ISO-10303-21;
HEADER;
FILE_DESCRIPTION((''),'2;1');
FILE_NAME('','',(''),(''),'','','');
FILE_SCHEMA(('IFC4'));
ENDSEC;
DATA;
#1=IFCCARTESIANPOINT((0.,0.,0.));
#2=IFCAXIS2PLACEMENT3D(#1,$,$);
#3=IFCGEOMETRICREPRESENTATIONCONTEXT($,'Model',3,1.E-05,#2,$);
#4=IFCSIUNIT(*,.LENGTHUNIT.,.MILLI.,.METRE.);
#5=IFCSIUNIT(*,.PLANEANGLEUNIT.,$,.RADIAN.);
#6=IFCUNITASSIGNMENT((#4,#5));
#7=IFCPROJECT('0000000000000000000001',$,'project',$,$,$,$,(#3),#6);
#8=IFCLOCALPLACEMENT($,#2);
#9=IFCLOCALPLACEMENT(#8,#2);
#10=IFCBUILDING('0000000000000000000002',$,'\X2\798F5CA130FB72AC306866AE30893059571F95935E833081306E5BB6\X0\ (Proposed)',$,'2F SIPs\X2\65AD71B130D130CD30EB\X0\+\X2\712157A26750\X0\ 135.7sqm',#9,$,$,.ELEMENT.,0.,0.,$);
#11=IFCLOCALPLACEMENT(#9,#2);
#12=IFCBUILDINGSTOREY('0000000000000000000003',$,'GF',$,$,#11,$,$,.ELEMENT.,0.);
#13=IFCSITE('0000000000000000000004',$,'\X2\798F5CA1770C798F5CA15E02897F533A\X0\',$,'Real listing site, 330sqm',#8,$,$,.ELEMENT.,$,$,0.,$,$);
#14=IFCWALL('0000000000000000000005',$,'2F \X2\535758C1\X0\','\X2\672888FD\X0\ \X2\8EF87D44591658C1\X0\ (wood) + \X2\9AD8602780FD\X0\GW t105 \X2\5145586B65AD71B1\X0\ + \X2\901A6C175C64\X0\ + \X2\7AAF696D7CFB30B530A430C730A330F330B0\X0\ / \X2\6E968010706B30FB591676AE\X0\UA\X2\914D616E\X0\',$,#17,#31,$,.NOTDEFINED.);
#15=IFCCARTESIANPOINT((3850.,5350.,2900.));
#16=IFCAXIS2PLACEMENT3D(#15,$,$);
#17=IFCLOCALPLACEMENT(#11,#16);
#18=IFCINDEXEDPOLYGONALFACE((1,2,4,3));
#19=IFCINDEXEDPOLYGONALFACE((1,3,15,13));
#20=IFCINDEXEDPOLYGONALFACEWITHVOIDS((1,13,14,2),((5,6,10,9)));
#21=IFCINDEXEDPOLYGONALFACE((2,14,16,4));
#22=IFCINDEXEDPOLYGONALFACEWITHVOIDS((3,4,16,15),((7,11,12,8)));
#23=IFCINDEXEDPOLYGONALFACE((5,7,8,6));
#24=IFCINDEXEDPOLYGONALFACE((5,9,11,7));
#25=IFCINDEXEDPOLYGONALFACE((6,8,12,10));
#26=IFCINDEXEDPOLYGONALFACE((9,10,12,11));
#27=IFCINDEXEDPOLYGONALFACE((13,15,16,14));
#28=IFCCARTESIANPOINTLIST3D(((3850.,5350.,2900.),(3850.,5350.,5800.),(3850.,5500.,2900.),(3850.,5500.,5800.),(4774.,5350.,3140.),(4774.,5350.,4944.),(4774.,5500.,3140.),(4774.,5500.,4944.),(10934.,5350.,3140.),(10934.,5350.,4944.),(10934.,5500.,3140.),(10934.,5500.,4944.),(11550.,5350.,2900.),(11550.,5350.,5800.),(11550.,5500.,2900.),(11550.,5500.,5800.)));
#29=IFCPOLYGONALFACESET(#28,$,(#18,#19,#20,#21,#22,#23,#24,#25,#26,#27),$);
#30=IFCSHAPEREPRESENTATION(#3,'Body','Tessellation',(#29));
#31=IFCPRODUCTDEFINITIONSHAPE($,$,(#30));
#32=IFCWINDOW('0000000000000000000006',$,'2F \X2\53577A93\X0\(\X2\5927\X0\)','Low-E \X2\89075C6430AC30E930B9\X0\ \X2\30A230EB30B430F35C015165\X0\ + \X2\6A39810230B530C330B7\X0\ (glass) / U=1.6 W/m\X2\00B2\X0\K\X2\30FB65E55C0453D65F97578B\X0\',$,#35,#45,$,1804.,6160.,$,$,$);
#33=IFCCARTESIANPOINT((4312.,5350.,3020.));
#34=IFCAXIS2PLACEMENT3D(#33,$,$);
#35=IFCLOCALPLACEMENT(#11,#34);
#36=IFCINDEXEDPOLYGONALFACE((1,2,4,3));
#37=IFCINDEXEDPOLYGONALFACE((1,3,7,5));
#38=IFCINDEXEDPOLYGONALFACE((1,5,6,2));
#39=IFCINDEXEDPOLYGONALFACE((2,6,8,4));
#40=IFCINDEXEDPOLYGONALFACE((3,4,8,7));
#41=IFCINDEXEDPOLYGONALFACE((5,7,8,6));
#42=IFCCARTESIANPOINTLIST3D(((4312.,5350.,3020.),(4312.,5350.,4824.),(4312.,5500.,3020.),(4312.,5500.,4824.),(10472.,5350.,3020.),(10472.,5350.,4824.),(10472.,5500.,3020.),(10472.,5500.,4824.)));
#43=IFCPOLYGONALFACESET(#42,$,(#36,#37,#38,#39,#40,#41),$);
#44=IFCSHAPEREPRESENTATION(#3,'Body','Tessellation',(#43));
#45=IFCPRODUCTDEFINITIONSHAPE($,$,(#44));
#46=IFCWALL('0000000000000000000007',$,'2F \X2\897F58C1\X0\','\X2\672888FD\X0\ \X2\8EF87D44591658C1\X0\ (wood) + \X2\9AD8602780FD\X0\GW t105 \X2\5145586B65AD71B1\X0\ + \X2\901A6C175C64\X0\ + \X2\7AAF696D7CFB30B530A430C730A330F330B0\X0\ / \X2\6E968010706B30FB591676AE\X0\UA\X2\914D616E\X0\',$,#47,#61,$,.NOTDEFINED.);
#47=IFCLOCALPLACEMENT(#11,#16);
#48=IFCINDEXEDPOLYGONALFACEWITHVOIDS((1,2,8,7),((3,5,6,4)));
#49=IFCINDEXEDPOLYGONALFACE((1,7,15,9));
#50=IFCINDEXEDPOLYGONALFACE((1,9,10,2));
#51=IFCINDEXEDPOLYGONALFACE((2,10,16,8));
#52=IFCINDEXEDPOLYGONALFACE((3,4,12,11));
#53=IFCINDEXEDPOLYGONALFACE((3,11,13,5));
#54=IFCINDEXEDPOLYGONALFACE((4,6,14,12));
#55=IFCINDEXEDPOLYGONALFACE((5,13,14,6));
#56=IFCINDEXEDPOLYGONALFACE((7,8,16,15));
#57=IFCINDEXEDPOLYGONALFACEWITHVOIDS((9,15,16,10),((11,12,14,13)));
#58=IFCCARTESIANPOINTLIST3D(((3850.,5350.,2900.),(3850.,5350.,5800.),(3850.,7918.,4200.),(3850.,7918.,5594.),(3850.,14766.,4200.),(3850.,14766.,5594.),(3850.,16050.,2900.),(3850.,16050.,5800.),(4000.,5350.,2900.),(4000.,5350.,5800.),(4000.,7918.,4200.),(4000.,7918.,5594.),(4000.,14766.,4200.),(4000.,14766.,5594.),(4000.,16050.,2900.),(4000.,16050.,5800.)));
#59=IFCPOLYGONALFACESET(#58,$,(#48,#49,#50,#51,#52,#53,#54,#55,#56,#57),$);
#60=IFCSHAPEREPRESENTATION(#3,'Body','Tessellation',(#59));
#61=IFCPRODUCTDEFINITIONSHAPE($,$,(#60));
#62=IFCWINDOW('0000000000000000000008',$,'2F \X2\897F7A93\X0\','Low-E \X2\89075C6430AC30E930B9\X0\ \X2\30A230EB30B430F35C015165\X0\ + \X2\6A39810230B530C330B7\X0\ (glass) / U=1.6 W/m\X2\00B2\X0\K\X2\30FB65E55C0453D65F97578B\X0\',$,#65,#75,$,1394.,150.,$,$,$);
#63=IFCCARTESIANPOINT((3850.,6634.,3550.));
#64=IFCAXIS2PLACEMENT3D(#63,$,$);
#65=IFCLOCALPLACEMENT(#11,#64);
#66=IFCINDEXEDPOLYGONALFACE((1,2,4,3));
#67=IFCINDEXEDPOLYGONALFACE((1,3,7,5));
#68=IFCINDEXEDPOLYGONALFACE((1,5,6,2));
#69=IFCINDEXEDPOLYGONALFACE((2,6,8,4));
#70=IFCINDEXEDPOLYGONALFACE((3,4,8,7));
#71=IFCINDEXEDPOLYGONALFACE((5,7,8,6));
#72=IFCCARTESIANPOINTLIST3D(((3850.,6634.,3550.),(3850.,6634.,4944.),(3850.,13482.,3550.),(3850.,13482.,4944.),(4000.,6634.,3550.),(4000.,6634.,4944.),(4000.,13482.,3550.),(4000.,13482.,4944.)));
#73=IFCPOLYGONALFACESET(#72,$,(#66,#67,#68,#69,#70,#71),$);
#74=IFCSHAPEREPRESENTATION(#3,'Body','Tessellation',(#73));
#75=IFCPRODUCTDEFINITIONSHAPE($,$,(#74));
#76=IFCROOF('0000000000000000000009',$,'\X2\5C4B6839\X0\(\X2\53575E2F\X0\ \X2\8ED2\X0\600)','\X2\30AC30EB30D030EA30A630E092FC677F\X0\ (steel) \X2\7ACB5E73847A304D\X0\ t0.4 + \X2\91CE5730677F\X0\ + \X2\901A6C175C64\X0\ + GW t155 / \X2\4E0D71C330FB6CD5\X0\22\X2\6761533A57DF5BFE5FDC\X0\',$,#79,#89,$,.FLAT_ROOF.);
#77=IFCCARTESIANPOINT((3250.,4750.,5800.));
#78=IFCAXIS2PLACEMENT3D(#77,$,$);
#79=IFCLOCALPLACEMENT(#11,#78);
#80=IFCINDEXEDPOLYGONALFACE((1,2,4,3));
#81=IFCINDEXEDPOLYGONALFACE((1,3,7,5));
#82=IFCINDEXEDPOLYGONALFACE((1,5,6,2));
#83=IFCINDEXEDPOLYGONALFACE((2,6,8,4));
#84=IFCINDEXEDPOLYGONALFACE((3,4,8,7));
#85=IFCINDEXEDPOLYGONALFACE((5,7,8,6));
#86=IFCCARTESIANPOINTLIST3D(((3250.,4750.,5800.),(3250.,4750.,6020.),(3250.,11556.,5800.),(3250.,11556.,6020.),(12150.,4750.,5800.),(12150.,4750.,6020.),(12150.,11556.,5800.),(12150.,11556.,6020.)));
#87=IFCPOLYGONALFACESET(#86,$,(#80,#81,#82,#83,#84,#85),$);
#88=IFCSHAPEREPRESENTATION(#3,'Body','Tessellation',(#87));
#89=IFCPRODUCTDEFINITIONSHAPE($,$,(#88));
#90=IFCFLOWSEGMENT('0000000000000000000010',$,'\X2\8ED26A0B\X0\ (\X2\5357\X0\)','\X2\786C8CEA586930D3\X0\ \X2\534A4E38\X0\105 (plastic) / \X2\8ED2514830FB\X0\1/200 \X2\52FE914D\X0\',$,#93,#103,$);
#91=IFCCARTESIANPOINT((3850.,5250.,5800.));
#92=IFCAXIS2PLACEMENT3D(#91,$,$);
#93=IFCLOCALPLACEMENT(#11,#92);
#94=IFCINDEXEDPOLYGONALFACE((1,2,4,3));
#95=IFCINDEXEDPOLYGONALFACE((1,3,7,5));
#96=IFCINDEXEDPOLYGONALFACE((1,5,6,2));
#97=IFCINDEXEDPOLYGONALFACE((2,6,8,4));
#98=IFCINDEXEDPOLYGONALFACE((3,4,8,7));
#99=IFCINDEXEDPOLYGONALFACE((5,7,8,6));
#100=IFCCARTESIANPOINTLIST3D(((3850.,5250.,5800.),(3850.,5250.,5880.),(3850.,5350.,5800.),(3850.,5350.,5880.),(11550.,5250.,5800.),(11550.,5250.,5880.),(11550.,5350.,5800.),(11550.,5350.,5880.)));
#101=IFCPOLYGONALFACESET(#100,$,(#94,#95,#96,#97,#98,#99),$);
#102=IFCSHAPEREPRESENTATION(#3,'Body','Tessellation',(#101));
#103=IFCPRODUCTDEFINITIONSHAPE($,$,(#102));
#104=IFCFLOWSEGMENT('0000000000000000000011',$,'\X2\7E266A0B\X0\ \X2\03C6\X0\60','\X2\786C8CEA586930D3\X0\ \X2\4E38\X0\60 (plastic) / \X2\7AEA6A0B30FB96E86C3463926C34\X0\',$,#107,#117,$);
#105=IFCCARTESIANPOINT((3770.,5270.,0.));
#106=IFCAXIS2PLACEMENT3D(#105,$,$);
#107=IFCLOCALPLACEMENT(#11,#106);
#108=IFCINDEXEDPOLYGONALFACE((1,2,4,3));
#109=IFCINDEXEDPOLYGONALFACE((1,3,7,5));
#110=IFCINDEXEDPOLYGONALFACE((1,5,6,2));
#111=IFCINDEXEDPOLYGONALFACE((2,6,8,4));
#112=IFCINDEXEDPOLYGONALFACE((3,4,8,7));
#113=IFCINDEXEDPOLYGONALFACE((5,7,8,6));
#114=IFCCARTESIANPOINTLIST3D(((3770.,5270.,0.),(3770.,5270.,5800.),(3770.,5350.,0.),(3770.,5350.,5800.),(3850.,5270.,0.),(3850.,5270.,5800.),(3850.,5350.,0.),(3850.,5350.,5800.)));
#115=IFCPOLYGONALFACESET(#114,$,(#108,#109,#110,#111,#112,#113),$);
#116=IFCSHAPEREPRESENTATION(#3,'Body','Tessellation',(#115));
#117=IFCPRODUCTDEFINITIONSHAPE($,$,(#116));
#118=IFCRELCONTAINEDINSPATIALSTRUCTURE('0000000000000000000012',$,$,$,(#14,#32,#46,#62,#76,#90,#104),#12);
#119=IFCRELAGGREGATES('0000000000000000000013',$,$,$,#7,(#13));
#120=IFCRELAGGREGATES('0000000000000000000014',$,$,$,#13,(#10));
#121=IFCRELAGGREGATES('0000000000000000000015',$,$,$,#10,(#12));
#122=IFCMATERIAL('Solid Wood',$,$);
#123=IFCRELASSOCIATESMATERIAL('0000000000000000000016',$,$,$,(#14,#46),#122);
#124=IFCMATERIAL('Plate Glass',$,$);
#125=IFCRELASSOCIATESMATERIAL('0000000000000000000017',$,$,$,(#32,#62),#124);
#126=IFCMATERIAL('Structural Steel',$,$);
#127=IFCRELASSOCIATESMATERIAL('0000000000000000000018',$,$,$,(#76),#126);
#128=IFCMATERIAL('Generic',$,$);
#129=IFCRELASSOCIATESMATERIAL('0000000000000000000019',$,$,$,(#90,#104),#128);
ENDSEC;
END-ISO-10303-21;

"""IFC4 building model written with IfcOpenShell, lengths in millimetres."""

from ifc_helpers import new_model, si_unit, frame, frame_2d, origin, place, context, project, spatial, rectangle, extrude, material, element, fill, save


model = new_model("IFC4")

# Units and contexts
model_context = context("Model", 3, precision=1e-05, world=origin())
ifc_project = project(units=[si_unit("LENGTHUNIT", "METRE", prefix="MILLI"), si_unit("PLANEANGLEUNIT", "RADIAN")], contexts=[model_context])

# Site, building, storey
site_placement = place(None, origin())
site = spatial("IfcSite", under=ifc_project, at=site_placement, Name="福岡県福岡市西区", ObjectType="Real listing site, 330sqm", CompositionType="ELEMENT", RefElevation=0.0)
building_placement = place(site_placement, origin())
building = spatial("IfcBuilding", under=site, at=building_placement, Name="福岡・犬と暮らす土間広めの家 (Proposed)", ObjectType="2F SIPs断熱パネル+無垢材 135.7sqm", CompositionType="ELEMENT", ElevationOfRefHeight=0.0, ElevationOfTerrain=0.0)
storey_placement = place(building_placement, origin())
storey = spatial("IfcBuildingStorey", under=building, at=storey_placement, Name="GF", CompositionType="ELEMENT", Elevation=0.0)

# Shared definitions
ifc_material_1 = material(Name="Solid Wood")

# Shared definitions
ifc_material_2 = material(Name="Plate Glass")

# Walls, openings, windows
wall_1_placement = place(storey_placement, frame((3850.0, 5350.0, 2900.0)))
wall_1 = element("IfcWall", 1, at=wall_1_placement, inside=storey, material=ifc_material_1, Name="2F 南壁", Description="木製 軸組外壁 (wood) + 高性能GW t105 充填断熱 + 通気層 + 窯業系サイディング / 準耐火・外皮UA配慮", PredefinedType="NOTDEFINED", context=model_context, shape_type="SweptSolid", body=[
    extrude(rectangle(XDim=7700.0, YDim=150.0, at=frame_2d((3850.0, 75.0))), frame((3850.0, 5350.0, 2900.0)), (0.0, 0.0, 1.0), 2900.0),
])
opening_1_placement = place(storey_placement, frame((4312.0, 5350.0, 3020.0)))
opening_1 = element("IfcOpeningElement", 2, at=opening_1_placement, cuts=wall_1, PredefinedType="NOTDEFINED", context=model_context, shape_type="SweptSolid", body=[
    extrude(rectangle(XDim=6160.0, YDim=150.0, at=frame_2d((3080.0, 75.0))), frame((4312.0, 5350.0, 3020.0)), (0.0, 0.0, 1.0), 1804.0),
])
window_1_placement = place(storey_placement, frame((4312.0, 5350.0, 3020.0)))
window_1 = element("IfcWindow", 3, at=window_1_placement, inside=storey, material=ifc_material_2, Name="2F 南窓(大)", Description="Low-E 複層ガラス アルゴン封入 + 樹脂サッシ (glass) / U=1.6 W/m²K・日射取得型", OverallHeight=1804.0, OverallWidth=6160.0, context=model_context, shape_type="SweptSolid", body=[
    extrude(rectangle(XDim=6160.0, YDim=150.0, at=frame_2d((3080.0, 75.0))), frame((4312.0, 5350.0, 3020.0)), (0.0, 0.0, 1.0), 1804.0),
])
fill(opening_1, window_1)
wall_2_placement = place(storey_placement, frame((3850.0, 5350.0, 2900.0)))
wall_2 = element("IfcWall", 4, at=wall_2_placement, inside=storey, material=ifc_material_1, Name="2F 西壁", Description="木製 軸組外壁 (wood) + 高性能GW t105 充填断熱 + 通気層 + 窯業系サイディング / 準耐火・外皮UA配慮", PredefinedType="NOTDEFINED", context=model_context, shape_type="SweptSolid", body=[
    extrude(rectangle(XDim=150.0, YDim=10700.0, at=frame_2d((75.0, 5350.0))), frame((3850.0, 5350.0, 2900.0)), (0.0, 0.0, 1.0), 2900.0),
])
opening_2_placement = place(storey_placement, frame((3850.0, 6634.0, 3550.0)))
opening_2 = element("IfcOpeningElement", 5, at=opening_2_placement, cuts=wall_2, PredefinedType="NOTDEFINED", context=model_context, shape_type="SweptSolid", body=[
    extrude(rectangle(XDim=150.0, YDim=6848.0, at=frame_2d((75.0, 3424.0))), frame((3850.0, 6634.0, 3550.0)), (0.0, 0.0, 1.0), 1394.0),
])
window_2_placement = place(storey_placement, frame((3850.0, 6634.0, 3550.0)))
window_2 = element("IfcWindow", 6, at=window_2_placement, inside=storey, material=ifc_material_2, Name="2F 西窓", Description="Low-E 複層ガラス アルゴン封入 + 樹脂サッシ (glass) / U=1.6 W/m²K・日射取得型", OverallHeight=1394.0, OverallWidth=150.0, context=model_context, shape_type="SweptSolid", body=[
    extrude(rectangle(XDim=150.0, YDim=6848.0, at=frame_2d((75.0, 3424.0))), frame((3850.0, 6634.0, 3550.0)), (0.0, 0.0, 1.0), 1394.0),
])
fill(opening_2, window_2)

# Roof
ifc_material_3 = material(Name="Structural Steel")
for number, where, name in (
    (7, (3250.0, 4750.0, 5800.0), "屋根(南帯 軒600)"),
):
    element("IfcRoof", number, at=place(storey_placement, frame(where)), inside=storey, material=ifc_material_3, Name=name, Description="ガルバリウム鋼板 (steel) 立平葺き t0.4 + 野地板 + 通気層 + GW t155 / 不燃・法22条区域対応", PredefinedType="FLAT_ROOF", context=model_context, shape_type="SweptSolid", body=[
        extrude(rectangle(XDim=8900.0, YDim=6806.0, at=frame_2d((4450.0, 3403.0))), frame((3250.0, 4750.0, 5800.0)), (0.0, 0.0, 1.0), 220.0),
    ])

# Flow segments
ifc_material_4 = material(Name="Generic")
flow_segment_1_placement = place(storey_placement, frame((3850.0, 5250.0, 5800.0)))
element("IfcFlowSegment", 8, at=flow_segment_1_placement, inside=storey, material=ifc_material_4, Name="軒樋 (南)", Description="硬質塩ビ 半丸105 (plastic) / 軒先・1/200 勾配", context=model_context, shape_type="SweptSolid", body=[
    extrude(rectangle(XDim=7700.0, YDim=100.0, at=frame_2d((3850.0, 50.0))), frame((3850.0, 5250.0, 5800.0)), (0.0, 0.0, 1.0), 80.0),
])
flow_segment_2_placement = place(storey_placement, frame((3770.0, 5270.0, 0.0)))
element("IfcFlowSegment", 9, at=flow_segment_2_placement, inside=storey, material=ifc_material_4, Name="縦樋 φ60", Description="硬質塩ビ 丸60 (plastic) / 竪樋・雨水排水", context=model_context, shape_type="SweptSolid", body=[
    extrude(rectangle(XDim=80.0, YDim=80.0, at=frame_2d((40.0, 40.0))), frame((3770.0, 5270.0, 0.0)), (0.0, 0.0, 1.0), 5800.0),
])

save(model, "model.ifc")
